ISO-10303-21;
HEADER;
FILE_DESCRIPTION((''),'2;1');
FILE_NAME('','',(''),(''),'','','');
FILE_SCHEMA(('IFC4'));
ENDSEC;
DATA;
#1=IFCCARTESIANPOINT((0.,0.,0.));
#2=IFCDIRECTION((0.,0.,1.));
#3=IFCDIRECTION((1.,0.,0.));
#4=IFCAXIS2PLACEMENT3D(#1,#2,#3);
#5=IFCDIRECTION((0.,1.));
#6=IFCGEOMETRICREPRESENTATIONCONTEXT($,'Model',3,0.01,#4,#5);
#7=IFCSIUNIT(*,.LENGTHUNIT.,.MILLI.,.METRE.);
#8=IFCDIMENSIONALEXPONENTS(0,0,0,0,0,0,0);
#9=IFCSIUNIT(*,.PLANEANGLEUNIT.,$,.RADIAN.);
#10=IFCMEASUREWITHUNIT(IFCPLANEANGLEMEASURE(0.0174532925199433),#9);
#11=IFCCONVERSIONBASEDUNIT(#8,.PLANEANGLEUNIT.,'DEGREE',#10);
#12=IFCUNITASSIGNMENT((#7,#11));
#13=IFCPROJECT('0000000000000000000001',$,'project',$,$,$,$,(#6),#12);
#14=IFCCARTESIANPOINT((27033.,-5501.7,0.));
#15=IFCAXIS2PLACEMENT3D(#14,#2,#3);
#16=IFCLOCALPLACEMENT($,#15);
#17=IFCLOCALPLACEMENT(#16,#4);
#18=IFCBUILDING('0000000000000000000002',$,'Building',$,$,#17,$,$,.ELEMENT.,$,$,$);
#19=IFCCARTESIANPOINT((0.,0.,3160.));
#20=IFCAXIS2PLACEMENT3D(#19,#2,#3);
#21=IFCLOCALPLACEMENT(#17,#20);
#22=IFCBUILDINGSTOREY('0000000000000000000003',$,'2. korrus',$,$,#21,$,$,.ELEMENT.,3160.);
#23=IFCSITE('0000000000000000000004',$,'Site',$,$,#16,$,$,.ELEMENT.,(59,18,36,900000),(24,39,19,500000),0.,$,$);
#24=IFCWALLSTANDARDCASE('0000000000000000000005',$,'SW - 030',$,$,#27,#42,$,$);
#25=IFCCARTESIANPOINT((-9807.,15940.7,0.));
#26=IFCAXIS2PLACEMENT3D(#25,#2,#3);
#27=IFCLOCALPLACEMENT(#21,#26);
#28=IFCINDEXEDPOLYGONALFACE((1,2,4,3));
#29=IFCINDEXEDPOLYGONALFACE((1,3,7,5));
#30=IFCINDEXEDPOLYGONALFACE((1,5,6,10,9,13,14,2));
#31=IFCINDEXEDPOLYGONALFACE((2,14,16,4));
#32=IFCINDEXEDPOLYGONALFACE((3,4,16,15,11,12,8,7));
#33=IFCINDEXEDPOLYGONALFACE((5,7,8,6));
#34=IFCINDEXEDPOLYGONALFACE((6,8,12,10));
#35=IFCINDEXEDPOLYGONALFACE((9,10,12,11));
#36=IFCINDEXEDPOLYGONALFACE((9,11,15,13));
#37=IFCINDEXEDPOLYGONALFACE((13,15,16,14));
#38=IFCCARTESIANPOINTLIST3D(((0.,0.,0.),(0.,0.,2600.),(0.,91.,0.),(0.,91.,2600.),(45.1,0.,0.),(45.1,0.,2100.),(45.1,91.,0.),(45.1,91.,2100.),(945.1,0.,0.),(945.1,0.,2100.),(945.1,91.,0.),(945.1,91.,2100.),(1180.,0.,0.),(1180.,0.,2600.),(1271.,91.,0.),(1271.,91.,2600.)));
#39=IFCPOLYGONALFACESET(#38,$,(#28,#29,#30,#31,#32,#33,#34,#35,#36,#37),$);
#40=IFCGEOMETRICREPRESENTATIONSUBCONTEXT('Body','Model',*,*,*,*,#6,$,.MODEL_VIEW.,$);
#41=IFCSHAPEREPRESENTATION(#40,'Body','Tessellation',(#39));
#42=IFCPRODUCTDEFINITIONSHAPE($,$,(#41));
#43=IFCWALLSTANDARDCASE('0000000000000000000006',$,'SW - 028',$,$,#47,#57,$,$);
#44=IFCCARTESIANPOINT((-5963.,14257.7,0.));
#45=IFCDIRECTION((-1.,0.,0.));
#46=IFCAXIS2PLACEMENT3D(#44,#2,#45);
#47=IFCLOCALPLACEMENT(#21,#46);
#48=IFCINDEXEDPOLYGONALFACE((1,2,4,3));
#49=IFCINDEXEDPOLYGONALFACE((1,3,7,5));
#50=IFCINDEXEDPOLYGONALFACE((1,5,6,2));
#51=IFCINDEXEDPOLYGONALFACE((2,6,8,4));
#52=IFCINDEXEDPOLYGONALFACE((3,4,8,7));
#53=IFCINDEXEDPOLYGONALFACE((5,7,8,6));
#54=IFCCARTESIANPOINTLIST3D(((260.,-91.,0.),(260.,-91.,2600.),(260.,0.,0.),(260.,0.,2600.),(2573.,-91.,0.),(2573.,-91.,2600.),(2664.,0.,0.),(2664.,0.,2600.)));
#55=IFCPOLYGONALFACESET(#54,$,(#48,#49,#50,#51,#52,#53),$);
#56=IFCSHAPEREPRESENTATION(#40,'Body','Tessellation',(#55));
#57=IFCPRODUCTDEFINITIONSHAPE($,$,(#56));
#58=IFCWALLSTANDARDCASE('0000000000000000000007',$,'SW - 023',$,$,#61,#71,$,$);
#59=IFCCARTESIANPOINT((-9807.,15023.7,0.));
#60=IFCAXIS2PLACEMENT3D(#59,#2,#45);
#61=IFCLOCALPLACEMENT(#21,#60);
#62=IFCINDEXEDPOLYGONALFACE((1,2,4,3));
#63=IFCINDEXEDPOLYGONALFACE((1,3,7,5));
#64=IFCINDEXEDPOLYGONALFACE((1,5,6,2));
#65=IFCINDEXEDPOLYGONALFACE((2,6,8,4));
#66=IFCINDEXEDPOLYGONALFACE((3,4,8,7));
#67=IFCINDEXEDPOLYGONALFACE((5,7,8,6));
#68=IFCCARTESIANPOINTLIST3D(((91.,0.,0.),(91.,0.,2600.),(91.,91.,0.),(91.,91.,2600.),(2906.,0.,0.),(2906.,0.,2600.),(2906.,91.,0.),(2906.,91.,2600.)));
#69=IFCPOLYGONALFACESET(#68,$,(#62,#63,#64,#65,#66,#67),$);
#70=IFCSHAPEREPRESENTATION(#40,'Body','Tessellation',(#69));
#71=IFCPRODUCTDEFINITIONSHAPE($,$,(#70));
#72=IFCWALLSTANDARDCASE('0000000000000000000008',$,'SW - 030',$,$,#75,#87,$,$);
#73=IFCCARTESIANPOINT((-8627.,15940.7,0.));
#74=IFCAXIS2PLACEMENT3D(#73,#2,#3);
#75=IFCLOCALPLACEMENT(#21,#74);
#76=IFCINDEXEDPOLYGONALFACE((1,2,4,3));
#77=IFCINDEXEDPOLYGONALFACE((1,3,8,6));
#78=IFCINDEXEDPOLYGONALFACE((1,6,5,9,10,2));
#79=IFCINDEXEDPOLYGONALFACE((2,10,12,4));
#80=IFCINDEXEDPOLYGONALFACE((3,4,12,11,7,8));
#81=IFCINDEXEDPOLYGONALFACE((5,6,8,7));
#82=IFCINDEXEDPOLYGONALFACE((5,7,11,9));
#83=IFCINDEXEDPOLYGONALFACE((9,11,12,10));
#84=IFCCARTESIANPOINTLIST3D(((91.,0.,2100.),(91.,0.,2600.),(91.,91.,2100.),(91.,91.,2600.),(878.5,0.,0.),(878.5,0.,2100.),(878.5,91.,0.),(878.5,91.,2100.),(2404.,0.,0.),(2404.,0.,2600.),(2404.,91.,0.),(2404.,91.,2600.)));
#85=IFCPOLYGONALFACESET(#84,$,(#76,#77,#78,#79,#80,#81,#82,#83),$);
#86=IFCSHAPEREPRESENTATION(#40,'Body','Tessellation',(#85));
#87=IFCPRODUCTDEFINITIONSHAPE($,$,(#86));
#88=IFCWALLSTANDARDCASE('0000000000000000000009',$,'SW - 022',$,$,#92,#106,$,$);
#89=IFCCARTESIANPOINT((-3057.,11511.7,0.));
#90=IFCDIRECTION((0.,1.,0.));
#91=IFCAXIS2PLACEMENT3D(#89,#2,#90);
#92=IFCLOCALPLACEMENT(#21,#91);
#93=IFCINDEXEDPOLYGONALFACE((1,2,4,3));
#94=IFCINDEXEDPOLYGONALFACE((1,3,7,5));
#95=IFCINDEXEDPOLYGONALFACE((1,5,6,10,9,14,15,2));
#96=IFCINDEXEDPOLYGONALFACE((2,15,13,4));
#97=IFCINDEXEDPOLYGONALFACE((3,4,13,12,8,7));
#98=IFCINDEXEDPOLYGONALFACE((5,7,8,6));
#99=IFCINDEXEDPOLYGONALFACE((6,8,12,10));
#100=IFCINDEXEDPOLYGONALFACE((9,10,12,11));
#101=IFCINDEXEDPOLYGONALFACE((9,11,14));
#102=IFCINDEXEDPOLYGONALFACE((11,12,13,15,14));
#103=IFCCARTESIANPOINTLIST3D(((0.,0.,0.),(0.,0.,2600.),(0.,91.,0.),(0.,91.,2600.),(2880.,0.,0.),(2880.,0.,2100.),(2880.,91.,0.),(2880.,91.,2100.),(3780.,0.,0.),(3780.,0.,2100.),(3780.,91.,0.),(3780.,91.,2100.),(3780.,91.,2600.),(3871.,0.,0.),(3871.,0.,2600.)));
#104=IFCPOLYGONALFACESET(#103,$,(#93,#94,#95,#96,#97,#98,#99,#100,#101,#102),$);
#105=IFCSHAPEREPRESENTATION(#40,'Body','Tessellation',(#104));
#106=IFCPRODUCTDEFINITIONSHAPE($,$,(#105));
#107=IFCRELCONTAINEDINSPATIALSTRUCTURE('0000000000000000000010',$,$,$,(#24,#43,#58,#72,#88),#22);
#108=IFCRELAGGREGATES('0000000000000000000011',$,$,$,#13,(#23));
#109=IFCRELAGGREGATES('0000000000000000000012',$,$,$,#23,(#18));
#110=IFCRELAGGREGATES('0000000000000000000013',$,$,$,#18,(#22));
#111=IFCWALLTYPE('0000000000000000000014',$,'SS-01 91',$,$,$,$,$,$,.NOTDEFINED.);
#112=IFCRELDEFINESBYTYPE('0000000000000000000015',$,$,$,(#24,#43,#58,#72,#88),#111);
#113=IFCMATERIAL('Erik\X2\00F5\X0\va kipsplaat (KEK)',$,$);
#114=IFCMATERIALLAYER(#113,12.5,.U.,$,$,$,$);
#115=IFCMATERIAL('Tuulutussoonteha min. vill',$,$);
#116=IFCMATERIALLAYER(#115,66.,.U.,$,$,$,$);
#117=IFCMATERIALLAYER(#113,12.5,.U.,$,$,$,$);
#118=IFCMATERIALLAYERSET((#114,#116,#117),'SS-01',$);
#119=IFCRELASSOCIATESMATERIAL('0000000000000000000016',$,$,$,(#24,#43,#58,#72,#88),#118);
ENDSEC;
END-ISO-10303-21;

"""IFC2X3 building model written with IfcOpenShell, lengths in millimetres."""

from ifc_helpers import new_model, entity, si_unit, converted_unit, direction, frame, origin_with_axes, origin_2d_with_axis, place, context, subcontext, project, spatial, polyline, rectangle, outline, extrude, material, layer, layer_set, layer_usage, type_object, element, save


model = new_model("IFC2X3")

# Units and contexts
model_context = context("Model", 3, precision=0.01, world=origin_with_axes(), true_north=direction((0.0, 1.0)))
body_context = subcontext(model_context, "Body", "Model", "MODEL_VIEW")
ifc_project = project(units=[si_unit("LENGTHUNIT", "METRE", prefix="MILLI"), converted_unit("PLANEANGLEUNIT", "DEGREE", entity("IfcPlaneAngleMeasure", 0.0174532925199433), si_unit("PLANEANGLEUNIT", "RADIAN"), dimensions=[0, 0, 0, 0, 0, 0, 0])], contexts=[model_context])

# Site, building, storey
site_placement = place(None, frame((27033.0, -5501.7, 0.0), z_axis=(0.0, 0.0, 1.0), x_axis=(1.0, 0.0, 0.0)))
site = spatial("IfcSite", under=ifc_project, at=site_placement, Name="Site", CompositionType="ELEMENT", RefLatitude=(59, 18, 36, 900000), RefLongitude=(24, 39, 19, 500000), RefElevation=0.0)
building_placement = place(site_placement, origin_with_axes())
building = spatial("IfcBuilding", under=site, at=building_placement, Name="Building", CompositionType="ELEMENT")
storey_placement = place(building_placement, frame((0.0, 0.0, 3160.0), z_axis=(0.0, 0.0, 1.0), x_axis=(1.0, 0.0, 0.0)))
storey = spatial("IfcBuildingStorey", under=building, at=storey_placement, Name="2. korrus", CompositionType="ELEMENT", Elevation=3160.0)

# Shared definitions
ifc_material_1 = material(Name="Erikõva kipsplaat (KEK)")
ifc_layer_1 = layer(ifc_material_1, 12.5, ventilated="UNKNOWN")
ifc_material_2 = material(Name="Tuulutussoonteha min. vill")
ifc_layer_2 = layer(ifc_material_2, 66.0, ventilated="UNKNOWN")
ifc_layer_3 = layer(ifc_material_1, 12.5, ventilated="UNKNOWN")
ifc_layer_set_1 = layer_set([ifc_layer_1, ifc_layer_2, ifc_layer_3], Name="SS-01")
wall_type_1 = type_object("IfcWallType", Name="SS-01 91", PredefinedType="NOTDEFINED")

# Wall, opening
ifc_layer_usage_1 = layer_usage(ifc_layer_set_1, "AXIS2", "NEGATIVE", 91.0)
wall_1_placement = place(storey_placement, frame((-9807.0, 15940.7, 0.0), z_axis=(0.0, 0.0, 1.0), x_axis=(1.0, 0.0, 0.0)))
wall_1 = element("IfcWallStandardCase", 1, at=wall_1_placement, inside=storey, type_object=wall_type_1, material=ifc_layer_usage_1, Name="SW - 030", context=body_context, shape_type="SweptSolid", body=[
    extrude(outline(polyline([(0.0, 0.0), (1180.0, 0.0), (1271.0, 91.0), (0.0, 91.0), (0.0, 0.0)])), origin_with_axes(), (0.0, 0.0, 1.0), 2600.0),
])
opening_1_placement = place(wall_1_placement, frame((495.1, 0.0, 0.0), z_axis=(0.0, 0.0, 1.0), x_axis=(1.0, 0.0, 0.0)))
element("IfcOpeningElement", 2, at=opening_1_placement, cuts=wall_1, context=body_context, shape_type="SweptSolid", body=[
    extrude(rectangle(XDim=900.0, YDim=2100.0, at=origin_2d_with_axis()), frame((0.0, -91.0, 1050.0), z_axis=(0.0, -1.0, 0.0), x_axis=(-1.0, 0.0, 0.0)), (0.0, 0.0, -1.0), 273.0),
    extrude(rectangle(XDim=974.0, YDim=2137.0, at=origin_2d_with_axis()), frame((0.0, 91.0, 1068.5), z_axis=(0.0, 1.0, 0.0), x_axis=(-1.0, 0.0, 0.0)), (0.0, 0.0, 1.0), 91.0),
])

# Wall
ifc_layer_usage_2 = layer_usage(ifc_layer_set_1, "AXIS2", "POSITIVE", -91.0)
wall_2_placement = place(storey_placement, frame((-5963.0, 14257.7, 0.0), z_axis=(0.0, 0.0, 1.0), x_axis=(-1.0, 0.0, 0.0)))
element("IfcWallStandardCase", 3, at=wall_2_placement, inside=storey, type_object=wall_type_1, material=ifc_layer_usage_2, Name="SW - 028", context=body_context, shape_type="SweptSolid", body=[
    extrude(outline(polyline([(260.0, -91.0), (2573.0, -91.0), (2664.0, 0.0), (260.0, 0.0), (260.0, -91.0)])), origin_with_axes(), (0.0, 0.0, 1.0), 2600.0),
])

# Wall
ifc_layer_usage_3 = layer_usage(ifc_layer_set_1, "AXIS2", "NEGATIVE", 91.0)
wall_3_placement = place(storey_placement, frame((-9807.0, 15023.7, 0.0), z_axis=(0.0, 0.0, 1.0), x_axis=(-1.0, 0.0, 0.0)))
element("IfcWallStandardCase", 4, at=wall_3_placement, inside=storey, type_object=wall_type_1, material=ifc_layer_usage_3, Name="SW - 023", context=body_context, shape_type="SweptSolid", body=[
    extrude(outline(polyline([(91.0, 0.0), (2906.0, 0.0), (2906.0, 91.0), (91.0, 91.0), (91.0, 0.0)])), origin_with_axes(), (0.0, 0.0, 1.0), 2600.0),
])

# Walls, openings
ifc_layer_usage_4 = layer_usage(ifc_layer_set_1, "AXIS2", "NEGATIVE", 91.0)
wall_4_placement = place(storey_placement, frame((-8627.0, 15940.7, 0.0), z_axis=(0.0, 0.0, 1.0), x_axis=(1.0, 0.0, 0.0)))
wall_4 = element("IfcWallStandardCase", 5, at=wall_4_placement, inside=storey, type_object=wall_type_1, material=ifc_layer_usage_4, Name="SW - 030", context=body_context, shape_type="SweptSolid", body=[
    extrude(outline(polyline([(91.0, 0.0), (2404.0, 0.0), (2404.0, 91.0), (91.0, 91.0), (91.0, 0.0)])), origin_with_axes(), (0.0, 0.0, 1.0), 2600.0),
])
opening_2_placement = place(wall_4_placement, frame((478.5, 0.0, 0.0), z_axis=(0.0, 0.0, 1.0), x_axis=(1.0, 0.0, 0.0)))
element("IfcOpeningElement", 6, at=opening_2_placement, cuts=wall_4, context=body_context, shape_type="SweptSolid", body=[
    extrude(rectangle(XDim=800.0, YDim=2100.0, at=origin_2d_with_axis()), frame((0.0, -91.0, 1050.0), z_axis=(0.0, 1.0, 0.0), x_axis=(1.0, 0.0, 0.0)), (0.0, 0.0, 1.0), 273.0),
])
ifc_layer_usage_5 = layer_usage(ifc_layer_set_1, "AXIS2", "NEGATIVE", 91.0)
wall_5_placement = place(storey_placement, frame((-3057.0, 11511.7, 0.0), z_axis=(0.0, 0.0, 1.0), x_axis=(0.0, 1.0, 0.0)))
wall_5 = element("IfcWallStandardCase", 7, at=wall_5_placement, inside=storey, type_object=wall_type_1, material=ifc_layer_usage_5, Name="SW - 022", context=body_context, shape_type="SweptSolid", body=[
    extrude(outline(polyline([(0.0, 0.0), (3871.0, 0.0), (3780.0, 91.0), (0.0, 91.0), (0.0, 0.0)])), origin_with_axes(), (0.0, 0.0, 1.0), 2600.0),
])
opening_3_placement = place(wall_5_placement, frame((3330.0, 0.0, 0.0), z_axis=(0.0, 0.0, 1.0), x_axis=(1.0, 0.0, 0.0)))
element("IfcOpeningElement", 8, at=opening_3_placement, cuts=wall_5, context=body_context, shape_type="SweptSolid", body=[
    extrude(rectangle(XDim=900.0, YDim=2100.0, at=origin_2d_with_axis()), frame((0.0, 91.0, 1050.0), z_axis=(0.0, -1.0, 0.0), x_axis=(1.0, 0.0, 0.0)), (0.0, 0.0, 1.0), 273.0),
    extrude(rectangle(XDim=974.0, YDim=2137.0, at=origin_2d_with_axis()), frame((0.0, 0.0, 1068.5), z_axis=(0.0, 1.0, 0.0), x_axis=(1.0, 0.0, 0.0)), (0.0, 0.0, -1.0), 91.0),
])

save(model, "model.ifc")
